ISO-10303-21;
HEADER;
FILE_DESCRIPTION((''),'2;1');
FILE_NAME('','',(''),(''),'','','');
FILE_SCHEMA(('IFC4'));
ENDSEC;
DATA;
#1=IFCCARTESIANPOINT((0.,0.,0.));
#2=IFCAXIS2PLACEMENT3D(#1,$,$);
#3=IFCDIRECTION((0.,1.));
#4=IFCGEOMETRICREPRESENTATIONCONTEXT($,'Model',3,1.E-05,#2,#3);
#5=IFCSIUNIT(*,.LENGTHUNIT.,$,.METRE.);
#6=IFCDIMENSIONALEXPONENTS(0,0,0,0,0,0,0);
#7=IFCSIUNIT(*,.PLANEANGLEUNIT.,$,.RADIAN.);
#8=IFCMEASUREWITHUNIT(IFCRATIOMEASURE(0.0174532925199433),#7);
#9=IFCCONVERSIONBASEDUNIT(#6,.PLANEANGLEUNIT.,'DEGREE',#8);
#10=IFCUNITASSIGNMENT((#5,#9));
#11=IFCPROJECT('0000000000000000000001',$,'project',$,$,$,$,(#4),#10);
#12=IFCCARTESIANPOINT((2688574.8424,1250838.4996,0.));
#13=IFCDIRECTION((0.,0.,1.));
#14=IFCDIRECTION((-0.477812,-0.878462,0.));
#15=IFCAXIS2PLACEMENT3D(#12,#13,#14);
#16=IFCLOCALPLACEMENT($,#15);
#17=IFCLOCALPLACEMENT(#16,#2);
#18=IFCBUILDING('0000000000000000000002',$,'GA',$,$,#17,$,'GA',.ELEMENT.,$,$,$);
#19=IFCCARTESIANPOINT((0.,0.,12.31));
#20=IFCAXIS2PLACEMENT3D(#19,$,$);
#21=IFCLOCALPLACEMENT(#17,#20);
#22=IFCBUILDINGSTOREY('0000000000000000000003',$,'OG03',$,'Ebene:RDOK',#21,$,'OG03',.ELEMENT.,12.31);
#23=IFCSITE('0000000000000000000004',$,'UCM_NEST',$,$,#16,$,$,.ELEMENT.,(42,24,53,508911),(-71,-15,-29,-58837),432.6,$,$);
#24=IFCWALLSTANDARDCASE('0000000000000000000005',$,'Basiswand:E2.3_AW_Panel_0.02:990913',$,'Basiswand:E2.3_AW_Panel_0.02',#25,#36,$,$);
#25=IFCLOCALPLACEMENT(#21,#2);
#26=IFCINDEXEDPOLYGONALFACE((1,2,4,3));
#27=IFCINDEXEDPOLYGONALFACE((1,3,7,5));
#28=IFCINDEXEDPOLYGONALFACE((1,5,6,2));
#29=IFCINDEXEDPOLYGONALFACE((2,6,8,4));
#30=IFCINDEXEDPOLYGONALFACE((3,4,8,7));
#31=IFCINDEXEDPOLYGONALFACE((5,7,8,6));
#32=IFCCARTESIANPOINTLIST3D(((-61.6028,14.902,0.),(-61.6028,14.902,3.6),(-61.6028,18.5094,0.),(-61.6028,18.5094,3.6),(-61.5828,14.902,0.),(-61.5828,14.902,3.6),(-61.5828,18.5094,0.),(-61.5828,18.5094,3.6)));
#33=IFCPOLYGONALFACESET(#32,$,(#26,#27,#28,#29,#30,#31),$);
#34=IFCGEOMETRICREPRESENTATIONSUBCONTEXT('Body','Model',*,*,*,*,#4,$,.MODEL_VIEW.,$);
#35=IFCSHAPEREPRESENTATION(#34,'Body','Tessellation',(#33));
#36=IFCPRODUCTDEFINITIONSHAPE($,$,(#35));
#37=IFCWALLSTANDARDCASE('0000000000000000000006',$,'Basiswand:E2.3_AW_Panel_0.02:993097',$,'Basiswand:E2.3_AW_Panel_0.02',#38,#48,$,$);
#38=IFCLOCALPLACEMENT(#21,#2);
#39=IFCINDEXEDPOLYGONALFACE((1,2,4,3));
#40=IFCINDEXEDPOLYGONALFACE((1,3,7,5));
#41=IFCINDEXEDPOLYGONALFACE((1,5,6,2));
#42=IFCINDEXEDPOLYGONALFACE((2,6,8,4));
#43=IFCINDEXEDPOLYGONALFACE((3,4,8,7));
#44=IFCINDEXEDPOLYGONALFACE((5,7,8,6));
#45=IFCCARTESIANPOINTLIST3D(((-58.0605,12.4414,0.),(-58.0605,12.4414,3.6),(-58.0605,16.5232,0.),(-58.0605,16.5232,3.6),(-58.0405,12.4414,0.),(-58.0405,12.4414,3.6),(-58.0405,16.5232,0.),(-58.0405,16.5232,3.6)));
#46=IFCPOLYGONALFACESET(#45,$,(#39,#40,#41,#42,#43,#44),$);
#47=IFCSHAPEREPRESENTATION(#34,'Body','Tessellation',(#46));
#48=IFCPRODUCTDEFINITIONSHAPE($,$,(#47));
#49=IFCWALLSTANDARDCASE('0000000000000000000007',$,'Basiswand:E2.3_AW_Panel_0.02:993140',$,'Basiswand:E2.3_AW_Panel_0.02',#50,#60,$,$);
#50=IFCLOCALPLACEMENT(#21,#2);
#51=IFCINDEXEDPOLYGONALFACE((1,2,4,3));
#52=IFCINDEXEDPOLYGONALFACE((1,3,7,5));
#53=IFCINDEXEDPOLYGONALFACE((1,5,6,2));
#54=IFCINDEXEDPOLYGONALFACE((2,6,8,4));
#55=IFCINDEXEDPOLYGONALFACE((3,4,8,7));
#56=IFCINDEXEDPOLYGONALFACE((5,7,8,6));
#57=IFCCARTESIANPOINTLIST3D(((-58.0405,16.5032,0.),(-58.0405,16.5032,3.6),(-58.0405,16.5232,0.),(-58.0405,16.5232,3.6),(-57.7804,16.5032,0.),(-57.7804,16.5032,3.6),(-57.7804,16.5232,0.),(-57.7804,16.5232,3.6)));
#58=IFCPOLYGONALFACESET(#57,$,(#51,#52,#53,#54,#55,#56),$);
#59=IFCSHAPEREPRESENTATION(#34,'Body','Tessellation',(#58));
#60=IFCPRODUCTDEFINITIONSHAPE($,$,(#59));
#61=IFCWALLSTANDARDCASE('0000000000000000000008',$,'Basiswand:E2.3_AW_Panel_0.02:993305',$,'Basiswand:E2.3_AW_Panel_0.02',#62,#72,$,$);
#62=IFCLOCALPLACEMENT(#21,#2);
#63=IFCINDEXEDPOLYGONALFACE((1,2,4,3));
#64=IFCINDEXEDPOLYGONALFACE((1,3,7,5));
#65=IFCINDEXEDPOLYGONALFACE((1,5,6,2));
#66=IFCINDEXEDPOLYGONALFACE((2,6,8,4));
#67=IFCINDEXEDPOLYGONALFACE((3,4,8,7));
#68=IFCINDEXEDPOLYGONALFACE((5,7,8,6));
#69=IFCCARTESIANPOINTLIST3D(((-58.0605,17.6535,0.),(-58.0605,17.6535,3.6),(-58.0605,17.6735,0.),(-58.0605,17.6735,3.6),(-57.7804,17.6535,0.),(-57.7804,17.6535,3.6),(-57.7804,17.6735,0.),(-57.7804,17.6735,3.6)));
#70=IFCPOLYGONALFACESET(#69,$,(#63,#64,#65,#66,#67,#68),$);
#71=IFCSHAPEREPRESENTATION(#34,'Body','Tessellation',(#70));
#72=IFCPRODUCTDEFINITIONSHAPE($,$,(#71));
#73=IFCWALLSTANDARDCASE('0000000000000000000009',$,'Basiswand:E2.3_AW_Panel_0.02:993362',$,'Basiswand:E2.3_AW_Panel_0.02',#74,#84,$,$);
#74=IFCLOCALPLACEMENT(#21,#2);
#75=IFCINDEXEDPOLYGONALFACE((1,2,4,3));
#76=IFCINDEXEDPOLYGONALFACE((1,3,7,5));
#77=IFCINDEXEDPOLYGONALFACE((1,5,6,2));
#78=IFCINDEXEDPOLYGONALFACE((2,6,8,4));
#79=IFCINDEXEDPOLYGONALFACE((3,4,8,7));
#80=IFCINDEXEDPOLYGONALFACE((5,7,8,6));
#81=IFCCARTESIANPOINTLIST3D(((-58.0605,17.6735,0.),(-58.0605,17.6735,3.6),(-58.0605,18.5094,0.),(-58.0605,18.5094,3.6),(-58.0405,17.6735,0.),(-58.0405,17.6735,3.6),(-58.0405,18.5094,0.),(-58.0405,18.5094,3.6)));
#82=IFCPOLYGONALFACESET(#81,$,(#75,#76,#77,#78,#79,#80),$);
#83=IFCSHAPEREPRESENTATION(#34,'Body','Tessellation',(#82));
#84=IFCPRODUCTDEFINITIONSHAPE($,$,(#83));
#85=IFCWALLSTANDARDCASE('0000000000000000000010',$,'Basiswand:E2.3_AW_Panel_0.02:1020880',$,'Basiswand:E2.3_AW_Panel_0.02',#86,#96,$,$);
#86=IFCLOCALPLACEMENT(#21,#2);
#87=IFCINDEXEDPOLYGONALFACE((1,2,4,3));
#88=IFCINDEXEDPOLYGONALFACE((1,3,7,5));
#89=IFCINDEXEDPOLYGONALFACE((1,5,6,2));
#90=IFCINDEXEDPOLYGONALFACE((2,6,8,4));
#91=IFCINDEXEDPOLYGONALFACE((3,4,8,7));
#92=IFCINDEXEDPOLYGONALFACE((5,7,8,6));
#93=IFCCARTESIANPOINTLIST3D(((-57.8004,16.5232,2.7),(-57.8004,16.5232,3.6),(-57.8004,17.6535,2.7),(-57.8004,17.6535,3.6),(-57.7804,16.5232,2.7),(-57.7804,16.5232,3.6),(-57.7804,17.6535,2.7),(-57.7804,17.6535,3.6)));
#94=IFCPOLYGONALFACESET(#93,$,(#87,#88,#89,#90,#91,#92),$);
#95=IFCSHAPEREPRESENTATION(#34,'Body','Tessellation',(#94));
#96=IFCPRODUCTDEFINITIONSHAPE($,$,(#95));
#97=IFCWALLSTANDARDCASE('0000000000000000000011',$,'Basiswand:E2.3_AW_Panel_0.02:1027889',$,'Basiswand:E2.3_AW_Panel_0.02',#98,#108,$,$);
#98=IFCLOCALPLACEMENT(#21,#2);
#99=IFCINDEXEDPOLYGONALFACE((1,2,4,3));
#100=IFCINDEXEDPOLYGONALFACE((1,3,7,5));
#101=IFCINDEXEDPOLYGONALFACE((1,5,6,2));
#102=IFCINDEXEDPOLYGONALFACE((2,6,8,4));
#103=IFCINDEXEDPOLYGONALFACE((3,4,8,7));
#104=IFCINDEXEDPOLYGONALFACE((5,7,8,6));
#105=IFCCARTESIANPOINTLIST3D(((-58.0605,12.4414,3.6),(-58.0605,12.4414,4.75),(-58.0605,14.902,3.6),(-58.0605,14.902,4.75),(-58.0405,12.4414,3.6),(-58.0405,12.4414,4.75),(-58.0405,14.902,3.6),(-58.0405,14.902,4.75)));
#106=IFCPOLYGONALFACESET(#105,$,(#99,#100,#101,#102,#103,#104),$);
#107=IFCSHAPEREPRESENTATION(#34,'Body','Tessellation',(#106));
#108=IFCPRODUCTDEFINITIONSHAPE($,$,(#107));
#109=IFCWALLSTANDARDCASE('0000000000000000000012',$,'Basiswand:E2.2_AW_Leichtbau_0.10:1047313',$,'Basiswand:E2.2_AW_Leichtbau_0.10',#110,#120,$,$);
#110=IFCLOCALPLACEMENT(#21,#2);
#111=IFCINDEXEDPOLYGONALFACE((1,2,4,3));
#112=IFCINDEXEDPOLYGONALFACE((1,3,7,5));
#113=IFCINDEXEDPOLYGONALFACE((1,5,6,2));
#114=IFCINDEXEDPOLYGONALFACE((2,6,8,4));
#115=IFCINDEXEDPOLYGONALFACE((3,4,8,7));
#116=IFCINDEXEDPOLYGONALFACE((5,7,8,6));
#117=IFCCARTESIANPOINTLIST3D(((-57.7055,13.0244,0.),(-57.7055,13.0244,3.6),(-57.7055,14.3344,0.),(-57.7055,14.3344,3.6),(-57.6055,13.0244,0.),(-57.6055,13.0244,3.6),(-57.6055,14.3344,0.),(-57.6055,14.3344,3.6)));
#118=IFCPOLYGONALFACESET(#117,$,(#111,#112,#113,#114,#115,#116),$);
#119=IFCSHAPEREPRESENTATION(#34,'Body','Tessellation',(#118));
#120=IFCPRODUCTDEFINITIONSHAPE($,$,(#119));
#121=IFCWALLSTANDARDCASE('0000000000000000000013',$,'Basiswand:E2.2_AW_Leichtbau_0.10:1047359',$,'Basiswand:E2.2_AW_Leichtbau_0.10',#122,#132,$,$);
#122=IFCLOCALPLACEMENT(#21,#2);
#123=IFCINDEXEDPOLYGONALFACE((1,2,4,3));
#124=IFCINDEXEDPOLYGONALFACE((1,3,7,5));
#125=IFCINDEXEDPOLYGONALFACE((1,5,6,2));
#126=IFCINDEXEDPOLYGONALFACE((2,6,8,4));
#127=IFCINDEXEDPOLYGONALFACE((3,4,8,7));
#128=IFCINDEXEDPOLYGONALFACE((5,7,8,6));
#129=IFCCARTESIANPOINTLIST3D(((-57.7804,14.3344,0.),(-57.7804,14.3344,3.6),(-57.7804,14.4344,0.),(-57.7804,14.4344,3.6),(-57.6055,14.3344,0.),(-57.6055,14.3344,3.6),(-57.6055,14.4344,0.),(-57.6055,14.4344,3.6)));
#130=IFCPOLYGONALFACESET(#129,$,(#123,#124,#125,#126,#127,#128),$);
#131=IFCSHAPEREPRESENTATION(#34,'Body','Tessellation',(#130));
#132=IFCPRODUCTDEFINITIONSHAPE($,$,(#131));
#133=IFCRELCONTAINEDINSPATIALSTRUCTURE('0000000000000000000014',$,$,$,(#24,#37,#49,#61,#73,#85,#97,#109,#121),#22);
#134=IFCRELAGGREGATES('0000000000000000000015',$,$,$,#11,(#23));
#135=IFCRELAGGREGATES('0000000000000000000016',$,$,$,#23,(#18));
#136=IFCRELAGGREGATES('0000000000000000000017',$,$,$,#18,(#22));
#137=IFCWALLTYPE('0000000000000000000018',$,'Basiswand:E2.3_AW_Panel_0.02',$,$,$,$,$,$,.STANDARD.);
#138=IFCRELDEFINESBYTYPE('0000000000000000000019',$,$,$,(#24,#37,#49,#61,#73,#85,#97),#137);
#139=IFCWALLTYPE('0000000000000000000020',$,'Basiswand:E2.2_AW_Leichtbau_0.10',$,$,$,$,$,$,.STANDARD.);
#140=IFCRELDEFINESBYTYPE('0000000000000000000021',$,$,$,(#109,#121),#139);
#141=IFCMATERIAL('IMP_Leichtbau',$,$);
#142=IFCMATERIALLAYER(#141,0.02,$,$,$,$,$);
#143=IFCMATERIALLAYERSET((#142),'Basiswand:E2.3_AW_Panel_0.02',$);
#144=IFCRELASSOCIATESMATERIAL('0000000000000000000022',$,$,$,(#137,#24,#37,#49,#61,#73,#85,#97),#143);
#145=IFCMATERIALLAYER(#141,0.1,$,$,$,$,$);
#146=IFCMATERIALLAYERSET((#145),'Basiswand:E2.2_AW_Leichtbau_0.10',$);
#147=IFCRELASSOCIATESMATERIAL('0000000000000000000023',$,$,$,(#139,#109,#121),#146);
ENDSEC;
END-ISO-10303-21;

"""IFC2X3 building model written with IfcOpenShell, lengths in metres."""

from ifc_helpers import new_model, entity, si_unit, converted_unit, direction, frame, frame_2d, origin, place, context, subcontext, project, spatial, rectangle, extrude, material, layer, layer_set, layer_usage, type_object, element, save


model = new_model("IFC2X3")

# Units and contexts
model_context = context("Model", 3, precision=1e-05, world=origin(), true_north=direction((0.0, 1.0)))
body_context = subcontext(model_context, "Body", "Model", "MODEL_VIEW")
ifc_project = project(units=[si_unit("LENGTHUNIT", "METRE"), converted_unit("PLANEANGLEUNIT", "DEGREE", entity("IfcRatioMeasure", 0.0174532925199433), si_unit("PLANEANGLEUNIT", "RADIAN"), dimensions=[0, 0, 0, 0, 0, 0, 0])], contexts=[model_context])

# Site, building, storey
site_placement = place(None, frame((2688574.8424, 1250838.4996, 0.0), z_axis=(0.0, 0.0, 1.0), x_axis=(-0.477812, -0.878462, 0.0)))
site = spatial("IfcSite", under=ifc_project, at=site_placement, Name="UCM_NEST", CompositionType="ELEMENT", RefLatitude=(42, 24, 53, 508911), RefLongitude=(-71, -15, -29, -58837), RefElevation=432.6)
building_placement = place(site_placement, origin())
building = spatial("IfcBuilding", under=site, at=building_placement, Name="GA", LongName="GA", CompositionType="ELEMENT")
storey_placement = place(building_placement, frame((0.0, 0.0, 12.31)))
storey = spatial("IfcBuildingStorey", under=building, at=storey_placement, Name="OG03", ObjectType="Ebene:RDOK", LongName="OG03", CompositionType="ELEMENT", Elevation=12.31)

# Shared definitions
ifc_material_1 = material(Name="IMP_Leichtbau")

# Walls
ifc_layer_1 = layer(ifc_material_1, 0.02)
ifc_layer_set_1 = layer_set([ifc_layer_1], Name="Basiswand:E2.3_AW_Panel_0.02")
wall_type_1 = type_object("IfcWallType", Name="Basiswand:E2.3_AW_Panel_0.02", PredefinedType="STANDARD", material=ifc_layer_set_1)
ifc_layer_usage_1 = layer_usage(ifc_layer_set_1, "AXIS2", "NEGATIVE", 0.01)
wall_1_placement = place(storey_placement, frame((-61.5928, 18.5094, 0.0), z_axis=(0.0, 0.0, 1.0), x_axis=(0.0, -1.0, 0.0)))
element("IfcWallStandardCase", 1, at=wall_1_placement, inside=storey, type_object=wall_type_1, material=ifc_layer_usage_1, Name="Basiswand:E2.3_AW_Panel_0.02:990913", ObjectType="Basiswand:E2.3_AW_Panel_0.02", context=body_context, shape_type="SweptSolid", body=[
    extrude(rectangle(XDim=3.6075, YDim=0.02, at=frame_2d((1.8037, 0.0), x_axis=(-1.0, 0.0))), origin(), (0.0, 0.0, 1.0), 3.6),
])
ifc_layer_usage_2 = layer_usage(ifc_layer_set_1, "AXIS2", "NEGATIVE", 0.01)
wall_2_placement = place(storey_placement, frame((-58.0505, 12.4414, 0.0), z_axis=(0.0, 0.0, 1.0), x_axis=(0.0, 1.0, 0.0)))
element("IfcWallStandardCase", 2, at=wall_2_placement, inside=storey, type_object=wall_type_1, material=ifc_layer_usage_2, Name="Basiswand:E2.3_AW_Panel_0.02:993097", ObjectType="Basiswand:E2.3_AW_Panel_0.02", context=body_context, shape_type="SweptSolid", body=[
    extrude(rectangle(XDim=4.0818, YDim=0.02, at=frame_2d((2.0409, 0.0), x_axis=(-1.0, 0.0))), origin(), (0.0, 0.0, 1.0), 3.6),
])
ifc_layer_usage_3 = layer_usage(ifc_layer_set_1, "AXIS2", "NEGATIVE", 0.01)
wall_3_placement = place(storey_placement, frame((-58.0405, 16.5132, 0.0)))
element("IfcWallStandardCase", 3, at=wall_3_placement, inside=storey, type_object=wall_type_1, material=ifc_layer_usage_3, Name="Basiswand:E2.3_AW_Panel_0.02:993140", ObjectType="Basiswand:E2.3_AW_Panel_0.02", context=body_context, shape_type="SweptSolid", body=[
    extrude(rectangle(XDim=0.2601, YDim=0.02, at=frame_2d((0.13, 0.0), x_axis=(-1.0, 0.0))), origin(), (0.0, 0.0, 1.0), 3.6),
])
ifc_layer_usage_4 = layer_usage(ifc_layer_set_1, "AXIS2", "NEGATIVE", 0.01)
wall_4_placement = place(storey_placement, frame((-57.7804, 17.6635, 0.0), z_axis=(0.0, 0.0, 1.0), x_axis=(-1.0, 0.0, 0.0)))
element("IfcWallStandardCase", 4, at=wall_4_placement, inside=storey, type_object=wall_type_1, material=ifc_layer_usage_4, Name="Basiswand:E2.3_AW_Panel_0.02:993305", ObjectType="Basiswand:E2.3_AW_Panel_0.02", context=body_context, shape_type="SweptSolid", body=[
    extrude(rectangle(XDim=0.2801, YDim=0.02, at=frame_2d((0.14, 0.0), x_axis=(-1.0, 0.0))), origin(), (0.0, 0.0, 1.0), 3.6),
])
ifc_layer_usage_5 = layer_usage(ifc_layer_set_1, "AXIS2", "NEGATIVE", 0.01)
wall_5_placement = place(storey_placement, frame((-58.0505, 17.6735, 0.0), z_axis=(0.0, 0.0, 1.0), x_axis=(0.0, 1.0, 0.0)))
element("IfcWallStandardCase", 5, at=wall_5_placement, inside=storey, type_object=wall_type_1, material=ifc_layer_usage_5, Name="Basiswand:E2.3_AW_Panel_0.02:993362", ObjectType="Basiswand:E2.3_AW_Panel_0.02", context=body_context, shape_type="SweptSolid", body=[
    extrude(rectangle(XDim=0.836, YDim=0.02, at=frame_2d((0.418, 0.0), x_axis=(-1.0, 0.0))), origin(), (0.0, 0.0, 1.0), 3.6),
])
ifc_layer_usage_6 = layer_usage(ifc_layer_set_1, "AXIS2", "NEGATIVE", 0.01)
wall_6_placement = place(storey_placement, frame((-57.7904, 16.5232, 2.7), z_axis=(0.0, 0.0, 1.0), x_axis=(0.0, 1.0, 0.0)))
element("IfcWallStandardCase", 6, at=wall_6_placement, inside=storey, type_object=wall_type_1, material=ifc_layer_usage_6, Name="Basiswand:E2.3_AW_Panel_0.02:1020880", ObjectType="Basiswand:E2.3_AW_Panel_0.02", context=body_context, shape_type="SweptSolid", body=[
    extrude(rectangle(XDim=1.1302, YDim=0.02, at=frame_2d((0.5651, 0.0), x_axis=(-1.0, 0.0))), origin(), (0.0, 0.0, 1.0), 0.9),
])
ifc_layer_usage_7 = layer_usage(ifc_layer_set_1, "AXIS2", "NEGATIVE", 0.01)
wall_7_placement = place(storey_placement, frame((-58.0505, 14.902, 3.6), z_axis=(0.0, 0.0, 1.0), x_axis=(0.0, -1.0, 0.0)))
element("IfcWallStandardCase", 7, at=wall_7_placement, inside=storey, type_object=wall_type_1, material=ifc_layer_usage_7, Name="Basiswand:E2.3_AW_Panel_0.02:1027889", ObjectType="Basiswand:E2.3_AW_Panel_0.02", context=body_context, shape_type="SweptSolid", body=[
    extrude(rectangle(XDim=2.4605, YDim=0.02, at=frame_2d((1.2303, 0.0), x_axis=(-1.0, 0.0))), origin(), (0.0, 0.0, 1.0), 1.15),
])

# Walls
ifc_layer_2 = layer(ifc_material_1, 0.1)
ifc_layer_set_2 = layer_set([ifc_layer_2], Name="Basiswand:E2.2_AW_Leichtbau_0.10")
ifc_layer_usage_8 = layer_usage(ifc_layer_set_2, "AXIS2", "NEGATIVE", 0.05)
wall_type_2 = type_object("IfcWallType", Name="Basiswand:E2.2_AW_Leichtbau_0.10", PredefinedType="STANDARD", material=ifc_layer_set_2)
wall_8_placement = place(storey_placement, frame((-57.6555, 13.0244, 0.0), z_axis=(0.0, 0.0, 1.0), x_axis=(0.0, 1.0, 0.0)))
element("IfcWallStandardCase", 8, at=wall_8_placement, inside=storey, type_object=wall_type_2, material=ifc_layer_usage_8, Name="Basiswand:E2.2_AW_Leichtbau_0.10:1047313", ObjectType="Basiswand:E2.2_AW_Leichtbau_0.10", context=body_context, shape_type="SweptSolid", body=[
    extrude(rectangle(XDim=1.31, YDim=0.1, at=frame_2d((0.655, 0.0), x_axis=(-1.0, 0.0))), origin(), (0.0, 0.0, 1.0), 3.6),
])
ifc_layer_usage_9 = layer_usage(ifc_layer_set_2, "AXIS2", "NEGATIVE", 0.05)
wall_9_placement = place(storey_placement, frame((-57.6055, 14.3844, 0.0), z_axis=(0.0, 0.0, 1.0), x_axis=(-1.0, 0.0, 0.0)))
element("IfcWallStandardCase", 9, at=wall_9_placement, inside=storey, type_object=wall_type_2, material=ifc_layer_usage_9, Name="Basiswand:E2.2_AW_Leichtbau_0.10:1047359", ObjectType="Basiswand:E2.2_AW_Leichtbau_0.10", context=body_context, shape_type="SweptSolid", body=[
    extrude(rectangle(XDim=0.175, YDim=0.1, at=frame_2d((0.0875, 0.0), x_axis=(-1.0, 0.0))), origin(), (0.0, 0.0, 1.0), 3.6),
])

save(model, "model.ifc")
